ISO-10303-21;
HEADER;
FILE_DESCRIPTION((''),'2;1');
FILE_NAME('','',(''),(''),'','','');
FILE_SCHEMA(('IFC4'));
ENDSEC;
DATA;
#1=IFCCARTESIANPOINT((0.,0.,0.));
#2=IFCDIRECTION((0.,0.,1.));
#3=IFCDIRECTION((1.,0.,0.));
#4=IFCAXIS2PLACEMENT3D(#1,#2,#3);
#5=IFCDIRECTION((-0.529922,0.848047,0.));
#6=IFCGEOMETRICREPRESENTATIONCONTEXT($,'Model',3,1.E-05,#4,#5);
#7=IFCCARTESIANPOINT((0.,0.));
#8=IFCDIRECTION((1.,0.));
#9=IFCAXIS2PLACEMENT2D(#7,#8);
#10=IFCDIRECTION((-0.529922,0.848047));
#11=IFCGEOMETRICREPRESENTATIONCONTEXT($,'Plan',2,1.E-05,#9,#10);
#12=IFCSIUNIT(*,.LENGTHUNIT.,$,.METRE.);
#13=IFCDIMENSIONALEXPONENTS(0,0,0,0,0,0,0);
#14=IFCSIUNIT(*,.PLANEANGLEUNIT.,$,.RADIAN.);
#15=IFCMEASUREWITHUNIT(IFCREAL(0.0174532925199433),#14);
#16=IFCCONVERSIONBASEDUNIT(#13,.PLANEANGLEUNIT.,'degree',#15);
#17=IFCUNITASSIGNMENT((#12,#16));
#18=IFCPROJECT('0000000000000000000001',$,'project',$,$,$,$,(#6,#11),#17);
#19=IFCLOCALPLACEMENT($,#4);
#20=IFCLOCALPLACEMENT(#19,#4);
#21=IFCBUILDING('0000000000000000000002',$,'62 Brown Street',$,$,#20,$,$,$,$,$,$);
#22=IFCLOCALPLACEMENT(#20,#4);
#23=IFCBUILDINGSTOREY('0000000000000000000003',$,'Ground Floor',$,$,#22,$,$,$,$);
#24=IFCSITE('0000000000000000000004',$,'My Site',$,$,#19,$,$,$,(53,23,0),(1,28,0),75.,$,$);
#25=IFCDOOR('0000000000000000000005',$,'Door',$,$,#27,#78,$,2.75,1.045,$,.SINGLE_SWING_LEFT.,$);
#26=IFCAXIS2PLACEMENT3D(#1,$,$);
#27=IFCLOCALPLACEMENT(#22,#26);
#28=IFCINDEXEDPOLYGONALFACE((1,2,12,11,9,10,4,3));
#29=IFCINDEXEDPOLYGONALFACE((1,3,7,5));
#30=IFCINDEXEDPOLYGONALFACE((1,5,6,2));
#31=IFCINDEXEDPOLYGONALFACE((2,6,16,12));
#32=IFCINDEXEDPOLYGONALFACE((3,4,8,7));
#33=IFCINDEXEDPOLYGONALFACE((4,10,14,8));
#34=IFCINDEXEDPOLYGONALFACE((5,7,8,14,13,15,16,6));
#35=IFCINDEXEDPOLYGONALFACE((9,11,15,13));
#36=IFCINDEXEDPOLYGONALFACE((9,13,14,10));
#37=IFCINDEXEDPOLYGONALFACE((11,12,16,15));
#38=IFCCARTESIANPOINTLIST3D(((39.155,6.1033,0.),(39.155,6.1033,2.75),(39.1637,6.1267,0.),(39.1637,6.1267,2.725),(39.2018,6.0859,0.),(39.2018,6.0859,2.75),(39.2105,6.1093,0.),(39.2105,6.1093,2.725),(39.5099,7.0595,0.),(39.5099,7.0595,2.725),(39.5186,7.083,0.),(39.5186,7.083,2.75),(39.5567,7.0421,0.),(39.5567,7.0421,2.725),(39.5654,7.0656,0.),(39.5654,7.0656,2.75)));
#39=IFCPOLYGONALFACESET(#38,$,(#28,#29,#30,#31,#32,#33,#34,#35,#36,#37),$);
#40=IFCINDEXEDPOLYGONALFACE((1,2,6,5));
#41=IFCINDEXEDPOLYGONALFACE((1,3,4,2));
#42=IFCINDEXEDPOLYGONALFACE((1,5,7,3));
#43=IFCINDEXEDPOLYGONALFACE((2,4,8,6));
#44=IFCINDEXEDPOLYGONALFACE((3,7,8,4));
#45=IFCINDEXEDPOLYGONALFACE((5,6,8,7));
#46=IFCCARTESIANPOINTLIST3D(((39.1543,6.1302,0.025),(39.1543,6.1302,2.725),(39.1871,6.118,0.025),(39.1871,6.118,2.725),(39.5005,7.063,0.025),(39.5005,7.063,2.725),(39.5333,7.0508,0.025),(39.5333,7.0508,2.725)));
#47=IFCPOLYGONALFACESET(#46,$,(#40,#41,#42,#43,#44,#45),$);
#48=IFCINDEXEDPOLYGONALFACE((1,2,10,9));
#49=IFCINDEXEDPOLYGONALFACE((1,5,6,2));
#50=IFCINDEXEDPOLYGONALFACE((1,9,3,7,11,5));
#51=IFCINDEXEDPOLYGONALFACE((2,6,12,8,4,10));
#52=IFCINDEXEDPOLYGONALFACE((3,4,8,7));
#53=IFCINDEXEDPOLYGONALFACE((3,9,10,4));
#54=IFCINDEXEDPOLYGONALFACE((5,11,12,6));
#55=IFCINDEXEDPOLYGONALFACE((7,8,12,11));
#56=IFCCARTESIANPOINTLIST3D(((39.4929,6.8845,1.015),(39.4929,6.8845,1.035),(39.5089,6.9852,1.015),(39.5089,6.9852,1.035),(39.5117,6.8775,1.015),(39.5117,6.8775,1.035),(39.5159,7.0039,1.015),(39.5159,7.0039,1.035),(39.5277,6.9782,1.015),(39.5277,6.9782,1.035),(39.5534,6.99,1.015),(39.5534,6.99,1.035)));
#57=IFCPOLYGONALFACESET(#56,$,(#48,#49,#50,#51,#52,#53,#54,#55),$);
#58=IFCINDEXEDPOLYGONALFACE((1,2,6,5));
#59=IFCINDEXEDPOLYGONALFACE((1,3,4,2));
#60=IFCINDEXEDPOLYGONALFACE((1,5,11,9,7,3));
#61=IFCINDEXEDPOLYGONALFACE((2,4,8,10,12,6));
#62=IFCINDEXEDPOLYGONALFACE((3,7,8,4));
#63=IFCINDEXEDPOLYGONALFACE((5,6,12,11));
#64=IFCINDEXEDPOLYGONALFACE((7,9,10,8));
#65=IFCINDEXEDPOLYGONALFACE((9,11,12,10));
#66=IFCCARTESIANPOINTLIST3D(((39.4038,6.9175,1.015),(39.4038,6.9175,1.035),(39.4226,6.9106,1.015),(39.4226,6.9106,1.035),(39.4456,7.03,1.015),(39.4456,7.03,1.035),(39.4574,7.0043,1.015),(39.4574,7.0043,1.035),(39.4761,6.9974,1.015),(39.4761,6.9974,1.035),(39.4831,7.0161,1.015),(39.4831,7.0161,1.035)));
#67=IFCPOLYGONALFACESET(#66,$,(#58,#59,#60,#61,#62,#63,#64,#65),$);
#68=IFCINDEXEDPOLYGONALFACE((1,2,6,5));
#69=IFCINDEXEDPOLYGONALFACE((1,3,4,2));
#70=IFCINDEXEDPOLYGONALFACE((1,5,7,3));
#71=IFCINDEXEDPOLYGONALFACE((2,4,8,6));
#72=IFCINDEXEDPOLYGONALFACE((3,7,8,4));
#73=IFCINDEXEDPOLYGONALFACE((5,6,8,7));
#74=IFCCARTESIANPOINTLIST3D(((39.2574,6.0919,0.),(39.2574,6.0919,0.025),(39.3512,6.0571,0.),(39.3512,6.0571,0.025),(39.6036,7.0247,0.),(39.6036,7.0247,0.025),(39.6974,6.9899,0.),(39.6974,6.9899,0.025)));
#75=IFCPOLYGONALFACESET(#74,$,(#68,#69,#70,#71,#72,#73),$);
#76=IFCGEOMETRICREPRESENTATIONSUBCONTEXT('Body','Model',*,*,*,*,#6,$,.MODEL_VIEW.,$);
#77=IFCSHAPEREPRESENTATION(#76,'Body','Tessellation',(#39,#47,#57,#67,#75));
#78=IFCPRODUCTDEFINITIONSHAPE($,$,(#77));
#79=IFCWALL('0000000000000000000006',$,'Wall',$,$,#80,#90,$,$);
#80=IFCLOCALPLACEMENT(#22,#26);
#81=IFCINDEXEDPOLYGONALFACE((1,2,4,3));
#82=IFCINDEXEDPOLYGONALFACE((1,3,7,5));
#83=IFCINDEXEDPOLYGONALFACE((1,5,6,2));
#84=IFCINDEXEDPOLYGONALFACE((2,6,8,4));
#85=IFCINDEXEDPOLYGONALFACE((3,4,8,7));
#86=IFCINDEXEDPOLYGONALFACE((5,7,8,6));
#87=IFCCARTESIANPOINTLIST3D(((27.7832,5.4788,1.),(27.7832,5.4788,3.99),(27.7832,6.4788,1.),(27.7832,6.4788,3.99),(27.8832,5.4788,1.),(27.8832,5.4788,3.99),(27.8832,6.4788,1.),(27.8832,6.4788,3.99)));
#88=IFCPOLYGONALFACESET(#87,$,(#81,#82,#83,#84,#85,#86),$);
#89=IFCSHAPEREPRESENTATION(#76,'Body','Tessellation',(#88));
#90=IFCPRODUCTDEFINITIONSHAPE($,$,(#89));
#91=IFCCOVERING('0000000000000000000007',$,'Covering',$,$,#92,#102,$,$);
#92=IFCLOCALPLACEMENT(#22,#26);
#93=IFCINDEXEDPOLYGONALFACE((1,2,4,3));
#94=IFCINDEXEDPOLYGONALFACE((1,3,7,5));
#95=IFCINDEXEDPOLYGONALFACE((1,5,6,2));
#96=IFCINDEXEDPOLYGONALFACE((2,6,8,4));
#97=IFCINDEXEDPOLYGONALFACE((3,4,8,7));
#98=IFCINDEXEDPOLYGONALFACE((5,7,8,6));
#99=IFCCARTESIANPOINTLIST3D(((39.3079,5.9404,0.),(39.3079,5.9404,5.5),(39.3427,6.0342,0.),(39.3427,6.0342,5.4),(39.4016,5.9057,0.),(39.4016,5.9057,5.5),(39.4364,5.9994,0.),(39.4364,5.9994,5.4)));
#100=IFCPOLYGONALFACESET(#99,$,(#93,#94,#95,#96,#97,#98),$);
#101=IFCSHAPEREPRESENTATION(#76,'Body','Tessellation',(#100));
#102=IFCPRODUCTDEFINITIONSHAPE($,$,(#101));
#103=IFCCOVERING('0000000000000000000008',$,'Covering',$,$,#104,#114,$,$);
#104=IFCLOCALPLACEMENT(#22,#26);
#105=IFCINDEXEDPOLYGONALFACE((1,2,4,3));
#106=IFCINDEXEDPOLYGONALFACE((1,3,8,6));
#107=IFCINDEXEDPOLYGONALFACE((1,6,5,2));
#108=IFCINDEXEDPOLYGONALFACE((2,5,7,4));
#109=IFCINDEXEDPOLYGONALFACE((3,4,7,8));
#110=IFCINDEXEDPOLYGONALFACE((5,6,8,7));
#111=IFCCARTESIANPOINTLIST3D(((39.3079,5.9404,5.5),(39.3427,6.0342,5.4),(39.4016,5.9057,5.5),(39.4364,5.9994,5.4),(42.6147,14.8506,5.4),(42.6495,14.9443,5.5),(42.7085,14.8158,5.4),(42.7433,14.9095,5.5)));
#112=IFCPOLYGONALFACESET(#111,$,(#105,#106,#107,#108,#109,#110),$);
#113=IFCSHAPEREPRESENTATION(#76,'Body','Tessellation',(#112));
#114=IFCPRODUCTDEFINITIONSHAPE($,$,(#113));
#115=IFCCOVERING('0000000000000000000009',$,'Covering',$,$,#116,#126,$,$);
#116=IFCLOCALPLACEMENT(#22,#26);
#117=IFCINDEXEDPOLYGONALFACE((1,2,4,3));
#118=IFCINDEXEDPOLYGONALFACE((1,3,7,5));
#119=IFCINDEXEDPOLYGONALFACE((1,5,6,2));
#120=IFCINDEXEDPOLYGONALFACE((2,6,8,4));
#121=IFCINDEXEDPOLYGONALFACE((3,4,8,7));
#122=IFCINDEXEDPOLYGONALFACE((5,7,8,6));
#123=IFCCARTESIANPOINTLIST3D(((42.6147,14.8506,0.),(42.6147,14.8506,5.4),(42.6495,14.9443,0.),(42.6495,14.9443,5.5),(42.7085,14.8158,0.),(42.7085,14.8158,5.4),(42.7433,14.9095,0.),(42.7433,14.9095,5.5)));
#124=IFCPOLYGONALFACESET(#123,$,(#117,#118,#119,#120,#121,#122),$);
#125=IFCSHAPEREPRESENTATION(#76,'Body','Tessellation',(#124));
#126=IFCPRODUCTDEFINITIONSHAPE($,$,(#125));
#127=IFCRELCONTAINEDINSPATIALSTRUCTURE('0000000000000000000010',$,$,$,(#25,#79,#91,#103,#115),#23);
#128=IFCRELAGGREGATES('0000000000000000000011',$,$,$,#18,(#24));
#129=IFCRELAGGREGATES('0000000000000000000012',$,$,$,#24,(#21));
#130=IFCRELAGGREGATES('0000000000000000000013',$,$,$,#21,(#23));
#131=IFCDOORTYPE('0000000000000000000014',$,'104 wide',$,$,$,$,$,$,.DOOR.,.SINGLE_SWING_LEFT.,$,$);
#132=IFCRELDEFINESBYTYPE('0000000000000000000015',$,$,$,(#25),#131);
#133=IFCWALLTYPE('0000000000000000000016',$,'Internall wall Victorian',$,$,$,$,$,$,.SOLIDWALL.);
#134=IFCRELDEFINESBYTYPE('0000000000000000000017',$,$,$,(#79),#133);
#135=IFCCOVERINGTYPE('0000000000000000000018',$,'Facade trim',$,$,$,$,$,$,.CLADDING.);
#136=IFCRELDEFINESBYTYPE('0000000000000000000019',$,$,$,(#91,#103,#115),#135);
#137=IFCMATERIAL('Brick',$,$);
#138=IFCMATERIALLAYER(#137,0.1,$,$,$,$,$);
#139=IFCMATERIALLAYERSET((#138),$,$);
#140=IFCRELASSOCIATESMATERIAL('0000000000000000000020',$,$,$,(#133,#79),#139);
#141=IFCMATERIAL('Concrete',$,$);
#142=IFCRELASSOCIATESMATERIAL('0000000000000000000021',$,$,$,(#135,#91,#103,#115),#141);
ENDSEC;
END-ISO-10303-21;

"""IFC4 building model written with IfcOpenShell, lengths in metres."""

from ifc_helpers import new_model, entity, si_unit, converted_unit, direction, frame, origin_with_axes, origin_2d_with_axis, place, context, subcontext, project, spatial, line, indexed_curve, rectangle, outline, extrude, clip, halfspace, shape, source, transform, mapped, material, layer, layer_set, layer_usage, material_profile, profile_set, profile_usage, type_object, type_shapes, element, save


model = new_model("IFC4")

# Units and contexts
model_context = context("Model", 3, precision=1e-05, world=origin_with_axes(), true_north=direction((-0.529922, 0.848047, 0.0)))
plan_context = context("Plan", 2, precision=1e-05, world=origin_2d_with_axis(), true_north=direction((-0.529922, 0.848047)))
body_context_1 = subcontext(model_context, "Body", "Model", "MODEL_VIEW")
body_context_2 = subcontext(plan_context, "Body", "Plan", "PLAN_VIEW")
ifc_project = project(units=[si_unit("LENGTHUNIT", "METRE"), converted_unit("PLANEANGLEUNIT", "degree", entity("IfcReal", 0.0174532925199433), si_unit("PLANEANGLEUNIT", "RADIAN"), dimensions=[0, 0, 0, 0, 0, 0, 0])], contexts=[model_context, plan_context])

# Site, building, storey
site_placement = place(None, origin_with_axes())
site = spatial("IfcSite", under=ifc_project, at=site_placement, Name="My Site", RefLatitude=(53, 23, 0), RefLongitude=(1, 28, 0), RefElevation=75.0)
building_placement = place(site_placement, origin_with_axes())
building = spatial("IfcBuilding", under=site, at=building_placement, Name="62 Brown Street")
storey_placement = place(building_placement, origin_with_axes())
storey = spatial("IfcBuildingStorey", under=building, at=storey_placement, Name="Ground Floor")

# Shared definitions
ifc_material_1 = material(Name="Concrete")

# Shared definitions
ifc_material_2 = material(Name="Brick")

# Shared definitions
placement_1 = place(storey_placement, frame((39.024, 5.1755, 0.0), z_axis=(0.0, 0.0, 1.0), x_axis=(0.347944, 0.937515, 0.0)))

# Door
door_type_1 = type_object("IfcDoorType", Name="104 wide", OperationType="SINGLE_SWING_LEFT", PredefinedType="DOOR")
shared_shape_1 = source(origin_with_axes(), body_context_1, "Body", "SweptSolid", [
    extrude(outline(indexed_curve([(0.0, 0.0), (0.0, 2.75), (1.045, 2.75), (1.045, 0.0), (1.02, 0.0), (1.02, 2.725), (0.025, 2.725), (0.025, 0.0)], segments=[line(1, 2, 3, 4, 5, 6, 7, 8, 1)])), frame((0.0, 0.15, 0.0), z_axis=(0.0, -1.0, 0.0), x_axis=(1.0, 0.0, 0.0)), (0.0, 0.0, -1.0), 0.05),
    extrude(outline(indexed_curve([(0.0, 0.0), (0.995, 0.0), (0.995, 0.035), (0.0, 0.035)], segments=[line(1, 2, 3, 4, 1)])), frame((0.025, 0.175, 0.025), z_axis=(0.0, 0.0, 1.0), x_axis=(1.0, 0.0, 0.0)), (0.0, 0.0, 1.0), 2.7),
    extrude(outline(indexed_curve([(0.0, 0.0), (0.0, -0.04), (-0.12, -0.04), (-0.12, -0.02), (-0.02, -0.02), (-0.02, 0.0)], segments=[line(1, 2, 3, 4, 5, 6, 1)])), frame((0.97, 0.175, 1.015), z_axis=(0.0, 0.0, 1.0), x_axis=(1.0, 0.0, 0.0)), (0.0, 0.0, 1.0), 0.02),
    extrude(outline(indexed_curve([(0.0, 0.0), (0.0, 0.04), (-0.12, 0.04), (-0.12, 0.02), (-0.02, 0.02), (-0.02, 0.0)], segments=[line(1, 2, 3, 4, 5, 6, 1)])), frame((0.97, 0.21, 1.015), z_axis=(0.0, 0.0, 1.0), x_axis=(1.0, 0.0, 0.0)), (0.0, 0.0, 1.0), 0.02),
    extrude(outline(indexed_curve([(0.0, 0.0), (0.995, 0.0), (0.995, 0.1), (0.0, 0.1)], segments=[line(1, 2, 3, 4, 1)])), frame((0.025, 0.0, 0.0), z_axis=(0.0, 0.0, 1.0), x_axis=(1.0, 0.0, 0.0)), (0.0, 0.0, 1.0), 0.025),
])
shared_shape_2 = source(origin_with_axes(), body_context_2, "Body", "Curve2D", [
    entity("IfcIndexedPolyCurve", entity("IfcCartesianPointList2D", [[0.0, 0.15], [0.025, 0.15], [0.025, 0.2], [0.0, 0.2]]), [entity("IfcLineIndex", [1, 2, 3, 4, 1])]),
    entity("IfcIndexedPolyCurve", entity("IfcCartesianPointList2D", [[1.045, 0.15], [1.02, 0.15], [1.02, 0.2], [1.045, 0.2]]), [entity("IfcLineIndex", [1, 2, 3, 4, 1])]),
    entity("IfcTrimmedCurve", entity("IfcEllipse", entity("IfcAxis2Placement2D", entity("IfcCartesianPoint", [0.06, 0.2]), entity("IfcDirection", [1.0, 0.0])), 0.96, 0.995), [entity("IfcCartesianPoint", [1.02, 0.2])], [entity("IfcCartesianPoint", [0.06, 1.195])], True, "CARTESIAN"),
    entity("IfcIndexedPolyCurve", entity("IfcCartesianPointList2D", [[0.025, 0.2], [0.06, 0.2], [0.06, 1.195], [0.025, 1.195]]), [entity("IfcLineIndex", [1, 2, 3, 4, 1])]),
])
type_shapes(door_type_1, [shared_shape_1, shared_shape_2])
placement_2 = place(placement_1, frame((0.9154, 0.0, 0.0), z_axis=(0.0, 0.0, 1.0), x_axis=(1.0, 0.0, 0.0)))
door_1_placement = place(placement_2, frame((0.0, 0.0, 0.0), z_axis=(0.0, 0.0, 1.0), x_axis=(1.0, 0.0, 0.0)))
element("IfcDoor", 1, at=door_1_placement, inside=storey, type_object=door_type_1, Name="Door", OperationType="SINGLE_SWING_LEFT", OverallHeight=2.75, OverallWidth=1.045, shapes=[
    shape(body_context_1, "Body", "MappedRepresentation", [mapped(shared_shape_1, transform((0.0, 0.0, 0.0), x_axis=(1.0, 0.0, 0.0), y_axis=(0.0, 1.0, 0.0), z_axis=(0.0, 0.0, 1.0), scale=1.0))]),
    shape(body_context_2, "Body", "MappedRepresentation", [mapped(shared_shape_2, transform((0.0, 0.0, 0.0), x_axis=(1.0, 0.0, 0.0), y_axis=(0.0, 1.0, 0.0), z_axis=(0.0, 0.0, 1.0), scale=1.0))]),
])

# Wall
ifc_layer_1 = layer(ifc_material_2, 0.1)
ifc_layer_set_1 = layer_set([ifc_layer_1])
ifc_layer_usage_1 = layer_usage(ifc_layer_set_1, "AXIS2", "POSITIVE", 0.0)
wall_type_1 = type_object("IfcWallType", Name="Internall wall Victorian", PredefinedType="SOLIDWALL", material=ifc_layer_set_1)
wall_1_placement = place(storey_placement, frame((27.8832, 5.4788, 1.0), z_axis=(0.0, 0.0, 1.0), x_axis=(0.0, 1.0, 0.0)))
element("IfcWall", 2, at=wall_1_placement, inside=storey, type_object=wall_type_1, material=ifc_layer_usage_1, Name="Wall", context=body_context_1, shape_type="SweptSolid", body=[
    extrude(outline(indexed_curve([(0.0, 0.0), (0.0, 0.1), (1.0, 0.1), (1.0, 0.0), (0.0, 0.0)], self_intersect=False)), origin_with_axes(), (0.0, 0.0, 1.0), 2.99),
])

# Coverings
ifc_material_profile_1 = material_profile(ifc_material_1, rectangle(XDim=0.1, YDim=0.1))
ifc_profile_set_1 = profile_set([ifc_material_profile_1], Name="cowl")
ifc_profile_usage_1 = profile_usage(ifc_profile_set_1, cardinal=5)
covering_type = type_object("IfcCoveringType", Name="Facade trim", PredefinedType="CLADDING", material=ifc_profile_set_1)
covering_1_placement = place(storey_placement, frame((39.3721, 5.9699, 0.0), z_axis=(0.0, 0.0, 1.0), x_axis=(0.347944, 0.937515, 0.0)))
element("IfcCovering", 3, at=covering_1_placement, inside=storey, type_object=covering_type, material=ifc_profile_usage_1, Name="Covering", context=body_context_1, shape_type="Clipping", body=[
    clip(extrude(rectangle(XDim=0.1, YDim=0.1), origin_with_axes(), (0.0, 0.0, 1.0), 5.5), halfspace(frame((-0.05, 34.8348, 5.5), z_axis=(0.707098, 0.0, 0.707116), x_axis=(0.707116, 0.0, -0.707098)), False)),
])
ifc_profile_usage_2 = profile_usage(ifc_profile_set_1, cardinal=5)
covering_2_placement = place(storey_placement, frame((39.3547, 5.923, 5.45), z_axis=(0.347944, 0.937515, 0.0), x_axis=(0.0, 0.0, -1.0)))
element("IfcCovering", 4, at=covering_2_placement, inside=storey, type_object=covering_type, material=ifc_profile_usage_2, Name="Covering", context=body_context_1, shape_type="Clipping", body=[
    clip(clip(extrude(rectangle(XDim=0.1, YDim=0.1), origin_with_axes(), (0.0, 0.0, 1.0), 9.604), halfspace(frame((-0.05, 34.8348, 9.604), z_axis=(0.707114, 0.0, 0.7071), x_axis=(0.7071, -0.000003, -0.707113)), False)), halfspace(frame((-0.05, 34.8348, 0.0), z_axis=(0.707116, 0.0, -0.707098), x_axis=(0.707098, 0.0, 0.707116)), False)),
])
ifc_profile_usage_3 = profile_usage(ifc_profile_set_1, cardinal=5)
covering_3_placement = place(storey_placement, frame((42.679, 14.8801, 5.5), z_axis=(0.0, 0.0, -1.0), x_axis=(-0.347944, -0.937515, 0.0)))
element("IfcCovering", 5, at=covering_3_placement, inside=storey, type_object=covering_type, material=ifc_profile_usage_3, Name="Covering", context=body_context_1, shape_type="Clipping", body=[
    clip(extrude(rectangle(XDim=0.1, YDim=0.1), origin_with_axes(), (0.0, 0.0, 1.0), 5.5), halfspace(frame((-0.05, 34.8348, 0.0), z_axis=(0.7071, 0.0, -0.707113), x_axis=(0.707113, -0.000003, 0.7071)), False)),
])

save(model, "model.ifc")
